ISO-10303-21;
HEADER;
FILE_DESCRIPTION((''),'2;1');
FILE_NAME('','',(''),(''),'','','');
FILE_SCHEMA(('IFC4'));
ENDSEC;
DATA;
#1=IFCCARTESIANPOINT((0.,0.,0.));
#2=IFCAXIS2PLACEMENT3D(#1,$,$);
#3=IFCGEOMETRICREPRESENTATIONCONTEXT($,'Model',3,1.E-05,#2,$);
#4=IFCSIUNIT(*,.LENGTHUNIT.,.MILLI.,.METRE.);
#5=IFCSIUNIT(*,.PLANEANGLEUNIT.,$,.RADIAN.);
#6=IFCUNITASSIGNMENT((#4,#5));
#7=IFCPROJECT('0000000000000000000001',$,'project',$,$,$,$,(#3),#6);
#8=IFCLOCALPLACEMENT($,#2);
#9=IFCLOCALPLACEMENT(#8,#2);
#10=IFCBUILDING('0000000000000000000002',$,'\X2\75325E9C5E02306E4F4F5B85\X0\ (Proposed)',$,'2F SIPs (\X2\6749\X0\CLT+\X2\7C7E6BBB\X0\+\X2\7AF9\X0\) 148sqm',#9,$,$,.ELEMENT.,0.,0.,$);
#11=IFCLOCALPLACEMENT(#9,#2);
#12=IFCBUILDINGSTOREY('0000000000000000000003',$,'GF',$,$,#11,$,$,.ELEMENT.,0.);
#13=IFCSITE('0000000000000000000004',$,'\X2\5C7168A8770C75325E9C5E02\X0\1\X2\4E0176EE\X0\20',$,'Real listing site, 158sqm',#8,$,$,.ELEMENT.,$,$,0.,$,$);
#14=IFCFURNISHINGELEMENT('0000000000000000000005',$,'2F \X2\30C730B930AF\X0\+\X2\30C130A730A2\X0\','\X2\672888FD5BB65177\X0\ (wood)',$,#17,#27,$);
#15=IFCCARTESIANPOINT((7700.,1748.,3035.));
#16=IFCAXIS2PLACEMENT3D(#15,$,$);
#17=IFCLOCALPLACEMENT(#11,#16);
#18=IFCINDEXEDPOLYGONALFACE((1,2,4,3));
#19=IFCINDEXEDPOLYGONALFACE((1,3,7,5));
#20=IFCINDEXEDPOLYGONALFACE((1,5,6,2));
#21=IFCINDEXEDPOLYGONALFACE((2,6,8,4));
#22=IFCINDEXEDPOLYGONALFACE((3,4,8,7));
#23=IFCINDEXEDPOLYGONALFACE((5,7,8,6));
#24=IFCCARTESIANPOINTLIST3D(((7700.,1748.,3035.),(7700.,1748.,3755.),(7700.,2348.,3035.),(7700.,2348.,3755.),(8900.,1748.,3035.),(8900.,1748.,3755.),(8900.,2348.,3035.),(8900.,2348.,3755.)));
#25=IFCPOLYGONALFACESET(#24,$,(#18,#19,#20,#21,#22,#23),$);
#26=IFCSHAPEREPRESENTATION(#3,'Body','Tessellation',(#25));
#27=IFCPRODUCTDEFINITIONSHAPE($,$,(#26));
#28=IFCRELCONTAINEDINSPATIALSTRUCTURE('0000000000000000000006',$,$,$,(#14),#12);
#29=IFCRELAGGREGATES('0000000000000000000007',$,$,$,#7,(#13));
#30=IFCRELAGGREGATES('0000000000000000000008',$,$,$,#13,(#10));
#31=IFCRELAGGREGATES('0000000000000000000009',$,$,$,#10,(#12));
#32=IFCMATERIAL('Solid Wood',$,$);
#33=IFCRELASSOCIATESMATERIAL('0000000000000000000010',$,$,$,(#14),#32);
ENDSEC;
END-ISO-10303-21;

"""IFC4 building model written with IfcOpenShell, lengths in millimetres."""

from ifc_helpers import new_model, si_unit, frame, frame_2d, origin, place, context, project, spatial, rectangle, extrude, material, element, save


model = new_model("IFC4")

# Units and contexts
model_context = context("Model", 3, precision=1e-05, world=origin())
ifc_project = project(units=[si_unit("LENGTHUNIT", "METRE", prefix="MILLI"), si_unit("PLANEANGLEUNIT", "RADIAN")], contexts=[model_context])

# Site, building, storey
site_placement = place(None, origin())
site = spatial("IfcSite", under=ifc_project, at=site_placement, Name="山梨県甲府市1丁目20", ObjectType="Real listing site, 158sqm", CompositionType="ELEMENT", RefElevation=0.0)
building_placement = place(site_placement, origin())
building = spatial("IfcBuilding", under=site, at=building_placement, Name="甲府市の住宅 (Proposed)", ObjectType="2F SIPs (杉CLT+籾殻+竹) 148sqm", CompositionType="ELEMENT", ElevationOfRefHeight=0.0, ElevationOfTerrain=0.0)
storey_placement = place(building_placement, origin())
storey = spatial("IfcBuildingStorey", under=building, at=storey_placement, Name="GF", CompositionType="ELEMENT", Elevation=0.0)

# Shared definitions
ifc_material_1 = material(Name="Solid Wood")

# Furnishing element
furnishing_1_placement = place(storey_placement, frame((7700.0, 1748.0, 3035.0)))
element("IfcFurnishingElement", 1, at=furnishing_1_placement, inside=storey, material=ifc_material_1, Name="2F デスク+チェア", Description="木製家具 (wood)", context=model_context, shape_type="SweptSolid", body=[
    extrude(rectangle(XDim=1200.0, YDim=600.0, at=frame_2d((600.0, 300.0))), frame((7700.0, 1748.0, 3035.0)), (0.0, 0.0, 1.0), 720.0),
])

save(model, "model.ifc")
